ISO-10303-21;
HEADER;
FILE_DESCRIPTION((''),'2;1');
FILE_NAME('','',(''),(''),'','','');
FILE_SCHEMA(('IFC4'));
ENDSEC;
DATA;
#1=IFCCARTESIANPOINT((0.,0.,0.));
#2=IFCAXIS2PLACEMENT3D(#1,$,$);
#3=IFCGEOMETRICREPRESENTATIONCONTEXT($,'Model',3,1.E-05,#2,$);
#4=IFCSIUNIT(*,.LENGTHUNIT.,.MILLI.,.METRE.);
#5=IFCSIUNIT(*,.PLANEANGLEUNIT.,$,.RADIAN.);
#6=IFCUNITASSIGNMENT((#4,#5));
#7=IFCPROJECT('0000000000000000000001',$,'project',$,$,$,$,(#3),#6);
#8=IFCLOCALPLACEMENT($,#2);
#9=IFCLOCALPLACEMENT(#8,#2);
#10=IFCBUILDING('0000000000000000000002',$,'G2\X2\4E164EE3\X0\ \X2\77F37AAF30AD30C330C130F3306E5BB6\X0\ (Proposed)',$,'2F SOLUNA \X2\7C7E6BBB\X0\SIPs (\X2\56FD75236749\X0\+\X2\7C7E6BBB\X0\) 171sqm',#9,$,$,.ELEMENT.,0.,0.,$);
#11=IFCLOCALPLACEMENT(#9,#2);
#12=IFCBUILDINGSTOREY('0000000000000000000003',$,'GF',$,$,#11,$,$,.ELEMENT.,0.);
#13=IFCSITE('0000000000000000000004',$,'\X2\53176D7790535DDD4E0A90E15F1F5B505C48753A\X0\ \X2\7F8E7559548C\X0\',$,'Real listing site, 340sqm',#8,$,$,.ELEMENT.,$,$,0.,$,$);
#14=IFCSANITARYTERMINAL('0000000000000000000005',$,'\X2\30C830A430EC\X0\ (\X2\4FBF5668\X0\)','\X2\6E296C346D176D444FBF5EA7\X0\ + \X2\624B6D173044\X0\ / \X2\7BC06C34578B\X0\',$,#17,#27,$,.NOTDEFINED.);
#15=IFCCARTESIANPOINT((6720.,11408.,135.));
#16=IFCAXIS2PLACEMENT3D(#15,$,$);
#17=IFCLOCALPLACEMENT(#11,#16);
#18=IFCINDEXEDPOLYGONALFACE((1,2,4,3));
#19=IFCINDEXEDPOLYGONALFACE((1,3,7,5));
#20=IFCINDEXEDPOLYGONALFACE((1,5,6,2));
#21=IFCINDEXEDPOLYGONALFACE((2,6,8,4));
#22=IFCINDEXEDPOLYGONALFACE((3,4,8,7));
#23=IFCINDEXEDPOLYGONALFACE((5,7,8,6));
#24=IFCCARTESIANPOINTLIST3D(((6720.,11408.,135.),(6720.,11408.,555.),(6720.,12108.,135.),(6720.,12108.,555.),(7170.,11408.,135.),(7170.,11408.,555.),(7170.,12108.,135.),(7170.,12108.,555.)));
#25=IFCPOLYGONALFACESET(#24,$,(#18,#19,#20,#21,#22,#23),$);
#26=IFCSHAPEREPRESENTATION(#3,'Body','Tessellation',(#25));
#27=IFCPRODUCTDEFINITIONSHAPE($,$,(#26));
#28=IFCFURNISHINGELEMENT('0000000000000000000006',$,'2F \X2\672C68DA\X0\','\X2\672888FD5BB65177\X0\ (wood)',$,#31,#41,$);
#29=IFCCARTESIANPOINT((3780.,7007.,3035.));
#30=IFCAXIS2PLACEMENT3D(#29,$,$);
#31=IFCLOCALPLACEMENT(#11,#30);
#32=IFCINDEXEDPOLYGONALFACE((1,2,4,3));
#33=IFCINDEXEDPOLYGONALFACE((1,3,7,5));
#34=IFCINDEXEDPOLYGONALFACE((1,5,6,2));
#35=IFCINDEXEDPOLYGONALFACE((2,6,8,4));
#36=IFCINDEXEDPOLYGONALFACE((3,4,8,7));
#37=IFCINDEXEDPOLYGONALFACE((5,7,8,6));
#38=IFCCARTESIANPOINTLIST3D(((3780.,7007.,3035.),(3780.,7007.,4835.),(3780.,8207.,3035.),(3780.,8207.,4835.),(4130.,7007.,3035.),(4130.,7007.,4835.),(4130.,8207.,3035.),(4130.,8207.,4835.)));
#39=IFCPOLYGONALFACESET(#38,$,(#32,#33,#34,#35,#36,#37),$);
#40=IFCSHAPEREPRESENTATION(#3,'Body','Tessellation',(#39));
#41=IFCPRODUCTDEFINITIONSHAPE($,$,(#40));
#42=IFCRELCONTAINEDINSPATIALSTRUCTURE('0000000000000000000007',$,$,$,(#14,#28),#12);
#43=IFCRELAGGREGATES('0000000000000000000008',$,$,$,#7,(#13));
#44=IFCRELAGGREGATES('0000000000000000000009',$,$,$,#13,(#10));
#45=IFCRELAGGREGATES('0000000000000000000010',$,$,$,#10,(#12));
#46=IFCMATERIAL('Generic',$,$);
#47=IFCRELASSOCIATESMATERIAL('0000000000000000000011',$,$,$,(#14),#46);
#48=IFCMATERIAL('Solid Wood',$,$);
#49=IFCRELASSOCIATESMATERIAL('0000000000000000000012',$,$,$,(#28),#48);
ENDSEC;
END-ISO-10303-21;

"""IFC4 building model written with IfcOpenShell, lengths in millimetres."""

from ifc_helpers import new_model, si_unit, frame, frame_2d, origin, place, context, project, spatial, rectangle, extrude, material, element, save


model = new_model("IFC4")

# Units and contexts
model_context = context("Model", 3, precision=1e-05, world=origin())
ifc_project = project(units=[si_unit("LENGTHUNIT", "METRE", prefix="MILLI"), si_unit("PLANEANGLEUNIT", "RADIAN")], contexts=[model_context])

# Site, building, storey
site_placement = place(None, origin())
site = spatial("IfcSite", under=ifc_project, at=site_placement, Name="北海道川上郡弟子屈町 美留和", ObjectType="Real listing site, 340sqm", CompositionType="ELEMENT", RefElevation=0.0)
building_placement = place(site_placement, origin())
building = spatial("IfcBuilding", under=site, at=building_placement, Name="G2世代 石窯キッチンの家 (Proposed)", ObjectType="2F SOLUNA 籾殻SIPs (国産杉+籾殻) 171sqm", CompositionType="ELEMENT", ElevationOfRefHeight=0.0, ElevationOfTerrain=0.0)
storey_placement = place(building_placement, origin())
storey = spatial("IfcBuildingStorey", under=building, at=storey_placement, Name="GF", CompositionType="ELEMENT", Elevation=0.0)

# Shared definitions
ifc_material_1 = material(Name="Solid Wood")
ifc_material_2 = material(Name="Generic")

# Sanitary terminal
sanitary_terminal_1_placement = place(storey_placement, frame((6720.0, 11408.0, 135.0)))
element("IfcSanitaryTerminal", 1, at=sanitary_terminal_1_placement, inside=storey, material=ifc_material_2, Name="トイレ (便器)", Description="温水洗浄便座 + 手洗い / 節水型", PredefinedType="NOTDEFINED", context=model_context, shape_type="SweptSolid", body=[
    extrude(rectangle(XDim=450.0, YDim=700.0, at=frame_2d((225.0, 350.0))), frame((6720.0, 11408.0, 135.0)), (0.0, 0.0, 1.0), 420.0),
])

# Furnishing element
furnishing_placement = place(storey_placement, frame((3780.0, 7007.0, 3035.0)))
element("IfcFurnishingElement", 2, at=furnishing_placement, inside=storey, material=ifc_material_1, Name="2F 本棚", Description="木製家具 (wood)", context=model_context, shape_type="SweptSolid", body=[
    extrude(rectangle(XDim=350.0, YDim=1200.0, at=frame_2d((175.0, 600.0))), frame((3780.0, 7007.0, 3035.0)), (0.0, 0.0, 1.0), 1800.0),
])

save(model, "model.ifc")
